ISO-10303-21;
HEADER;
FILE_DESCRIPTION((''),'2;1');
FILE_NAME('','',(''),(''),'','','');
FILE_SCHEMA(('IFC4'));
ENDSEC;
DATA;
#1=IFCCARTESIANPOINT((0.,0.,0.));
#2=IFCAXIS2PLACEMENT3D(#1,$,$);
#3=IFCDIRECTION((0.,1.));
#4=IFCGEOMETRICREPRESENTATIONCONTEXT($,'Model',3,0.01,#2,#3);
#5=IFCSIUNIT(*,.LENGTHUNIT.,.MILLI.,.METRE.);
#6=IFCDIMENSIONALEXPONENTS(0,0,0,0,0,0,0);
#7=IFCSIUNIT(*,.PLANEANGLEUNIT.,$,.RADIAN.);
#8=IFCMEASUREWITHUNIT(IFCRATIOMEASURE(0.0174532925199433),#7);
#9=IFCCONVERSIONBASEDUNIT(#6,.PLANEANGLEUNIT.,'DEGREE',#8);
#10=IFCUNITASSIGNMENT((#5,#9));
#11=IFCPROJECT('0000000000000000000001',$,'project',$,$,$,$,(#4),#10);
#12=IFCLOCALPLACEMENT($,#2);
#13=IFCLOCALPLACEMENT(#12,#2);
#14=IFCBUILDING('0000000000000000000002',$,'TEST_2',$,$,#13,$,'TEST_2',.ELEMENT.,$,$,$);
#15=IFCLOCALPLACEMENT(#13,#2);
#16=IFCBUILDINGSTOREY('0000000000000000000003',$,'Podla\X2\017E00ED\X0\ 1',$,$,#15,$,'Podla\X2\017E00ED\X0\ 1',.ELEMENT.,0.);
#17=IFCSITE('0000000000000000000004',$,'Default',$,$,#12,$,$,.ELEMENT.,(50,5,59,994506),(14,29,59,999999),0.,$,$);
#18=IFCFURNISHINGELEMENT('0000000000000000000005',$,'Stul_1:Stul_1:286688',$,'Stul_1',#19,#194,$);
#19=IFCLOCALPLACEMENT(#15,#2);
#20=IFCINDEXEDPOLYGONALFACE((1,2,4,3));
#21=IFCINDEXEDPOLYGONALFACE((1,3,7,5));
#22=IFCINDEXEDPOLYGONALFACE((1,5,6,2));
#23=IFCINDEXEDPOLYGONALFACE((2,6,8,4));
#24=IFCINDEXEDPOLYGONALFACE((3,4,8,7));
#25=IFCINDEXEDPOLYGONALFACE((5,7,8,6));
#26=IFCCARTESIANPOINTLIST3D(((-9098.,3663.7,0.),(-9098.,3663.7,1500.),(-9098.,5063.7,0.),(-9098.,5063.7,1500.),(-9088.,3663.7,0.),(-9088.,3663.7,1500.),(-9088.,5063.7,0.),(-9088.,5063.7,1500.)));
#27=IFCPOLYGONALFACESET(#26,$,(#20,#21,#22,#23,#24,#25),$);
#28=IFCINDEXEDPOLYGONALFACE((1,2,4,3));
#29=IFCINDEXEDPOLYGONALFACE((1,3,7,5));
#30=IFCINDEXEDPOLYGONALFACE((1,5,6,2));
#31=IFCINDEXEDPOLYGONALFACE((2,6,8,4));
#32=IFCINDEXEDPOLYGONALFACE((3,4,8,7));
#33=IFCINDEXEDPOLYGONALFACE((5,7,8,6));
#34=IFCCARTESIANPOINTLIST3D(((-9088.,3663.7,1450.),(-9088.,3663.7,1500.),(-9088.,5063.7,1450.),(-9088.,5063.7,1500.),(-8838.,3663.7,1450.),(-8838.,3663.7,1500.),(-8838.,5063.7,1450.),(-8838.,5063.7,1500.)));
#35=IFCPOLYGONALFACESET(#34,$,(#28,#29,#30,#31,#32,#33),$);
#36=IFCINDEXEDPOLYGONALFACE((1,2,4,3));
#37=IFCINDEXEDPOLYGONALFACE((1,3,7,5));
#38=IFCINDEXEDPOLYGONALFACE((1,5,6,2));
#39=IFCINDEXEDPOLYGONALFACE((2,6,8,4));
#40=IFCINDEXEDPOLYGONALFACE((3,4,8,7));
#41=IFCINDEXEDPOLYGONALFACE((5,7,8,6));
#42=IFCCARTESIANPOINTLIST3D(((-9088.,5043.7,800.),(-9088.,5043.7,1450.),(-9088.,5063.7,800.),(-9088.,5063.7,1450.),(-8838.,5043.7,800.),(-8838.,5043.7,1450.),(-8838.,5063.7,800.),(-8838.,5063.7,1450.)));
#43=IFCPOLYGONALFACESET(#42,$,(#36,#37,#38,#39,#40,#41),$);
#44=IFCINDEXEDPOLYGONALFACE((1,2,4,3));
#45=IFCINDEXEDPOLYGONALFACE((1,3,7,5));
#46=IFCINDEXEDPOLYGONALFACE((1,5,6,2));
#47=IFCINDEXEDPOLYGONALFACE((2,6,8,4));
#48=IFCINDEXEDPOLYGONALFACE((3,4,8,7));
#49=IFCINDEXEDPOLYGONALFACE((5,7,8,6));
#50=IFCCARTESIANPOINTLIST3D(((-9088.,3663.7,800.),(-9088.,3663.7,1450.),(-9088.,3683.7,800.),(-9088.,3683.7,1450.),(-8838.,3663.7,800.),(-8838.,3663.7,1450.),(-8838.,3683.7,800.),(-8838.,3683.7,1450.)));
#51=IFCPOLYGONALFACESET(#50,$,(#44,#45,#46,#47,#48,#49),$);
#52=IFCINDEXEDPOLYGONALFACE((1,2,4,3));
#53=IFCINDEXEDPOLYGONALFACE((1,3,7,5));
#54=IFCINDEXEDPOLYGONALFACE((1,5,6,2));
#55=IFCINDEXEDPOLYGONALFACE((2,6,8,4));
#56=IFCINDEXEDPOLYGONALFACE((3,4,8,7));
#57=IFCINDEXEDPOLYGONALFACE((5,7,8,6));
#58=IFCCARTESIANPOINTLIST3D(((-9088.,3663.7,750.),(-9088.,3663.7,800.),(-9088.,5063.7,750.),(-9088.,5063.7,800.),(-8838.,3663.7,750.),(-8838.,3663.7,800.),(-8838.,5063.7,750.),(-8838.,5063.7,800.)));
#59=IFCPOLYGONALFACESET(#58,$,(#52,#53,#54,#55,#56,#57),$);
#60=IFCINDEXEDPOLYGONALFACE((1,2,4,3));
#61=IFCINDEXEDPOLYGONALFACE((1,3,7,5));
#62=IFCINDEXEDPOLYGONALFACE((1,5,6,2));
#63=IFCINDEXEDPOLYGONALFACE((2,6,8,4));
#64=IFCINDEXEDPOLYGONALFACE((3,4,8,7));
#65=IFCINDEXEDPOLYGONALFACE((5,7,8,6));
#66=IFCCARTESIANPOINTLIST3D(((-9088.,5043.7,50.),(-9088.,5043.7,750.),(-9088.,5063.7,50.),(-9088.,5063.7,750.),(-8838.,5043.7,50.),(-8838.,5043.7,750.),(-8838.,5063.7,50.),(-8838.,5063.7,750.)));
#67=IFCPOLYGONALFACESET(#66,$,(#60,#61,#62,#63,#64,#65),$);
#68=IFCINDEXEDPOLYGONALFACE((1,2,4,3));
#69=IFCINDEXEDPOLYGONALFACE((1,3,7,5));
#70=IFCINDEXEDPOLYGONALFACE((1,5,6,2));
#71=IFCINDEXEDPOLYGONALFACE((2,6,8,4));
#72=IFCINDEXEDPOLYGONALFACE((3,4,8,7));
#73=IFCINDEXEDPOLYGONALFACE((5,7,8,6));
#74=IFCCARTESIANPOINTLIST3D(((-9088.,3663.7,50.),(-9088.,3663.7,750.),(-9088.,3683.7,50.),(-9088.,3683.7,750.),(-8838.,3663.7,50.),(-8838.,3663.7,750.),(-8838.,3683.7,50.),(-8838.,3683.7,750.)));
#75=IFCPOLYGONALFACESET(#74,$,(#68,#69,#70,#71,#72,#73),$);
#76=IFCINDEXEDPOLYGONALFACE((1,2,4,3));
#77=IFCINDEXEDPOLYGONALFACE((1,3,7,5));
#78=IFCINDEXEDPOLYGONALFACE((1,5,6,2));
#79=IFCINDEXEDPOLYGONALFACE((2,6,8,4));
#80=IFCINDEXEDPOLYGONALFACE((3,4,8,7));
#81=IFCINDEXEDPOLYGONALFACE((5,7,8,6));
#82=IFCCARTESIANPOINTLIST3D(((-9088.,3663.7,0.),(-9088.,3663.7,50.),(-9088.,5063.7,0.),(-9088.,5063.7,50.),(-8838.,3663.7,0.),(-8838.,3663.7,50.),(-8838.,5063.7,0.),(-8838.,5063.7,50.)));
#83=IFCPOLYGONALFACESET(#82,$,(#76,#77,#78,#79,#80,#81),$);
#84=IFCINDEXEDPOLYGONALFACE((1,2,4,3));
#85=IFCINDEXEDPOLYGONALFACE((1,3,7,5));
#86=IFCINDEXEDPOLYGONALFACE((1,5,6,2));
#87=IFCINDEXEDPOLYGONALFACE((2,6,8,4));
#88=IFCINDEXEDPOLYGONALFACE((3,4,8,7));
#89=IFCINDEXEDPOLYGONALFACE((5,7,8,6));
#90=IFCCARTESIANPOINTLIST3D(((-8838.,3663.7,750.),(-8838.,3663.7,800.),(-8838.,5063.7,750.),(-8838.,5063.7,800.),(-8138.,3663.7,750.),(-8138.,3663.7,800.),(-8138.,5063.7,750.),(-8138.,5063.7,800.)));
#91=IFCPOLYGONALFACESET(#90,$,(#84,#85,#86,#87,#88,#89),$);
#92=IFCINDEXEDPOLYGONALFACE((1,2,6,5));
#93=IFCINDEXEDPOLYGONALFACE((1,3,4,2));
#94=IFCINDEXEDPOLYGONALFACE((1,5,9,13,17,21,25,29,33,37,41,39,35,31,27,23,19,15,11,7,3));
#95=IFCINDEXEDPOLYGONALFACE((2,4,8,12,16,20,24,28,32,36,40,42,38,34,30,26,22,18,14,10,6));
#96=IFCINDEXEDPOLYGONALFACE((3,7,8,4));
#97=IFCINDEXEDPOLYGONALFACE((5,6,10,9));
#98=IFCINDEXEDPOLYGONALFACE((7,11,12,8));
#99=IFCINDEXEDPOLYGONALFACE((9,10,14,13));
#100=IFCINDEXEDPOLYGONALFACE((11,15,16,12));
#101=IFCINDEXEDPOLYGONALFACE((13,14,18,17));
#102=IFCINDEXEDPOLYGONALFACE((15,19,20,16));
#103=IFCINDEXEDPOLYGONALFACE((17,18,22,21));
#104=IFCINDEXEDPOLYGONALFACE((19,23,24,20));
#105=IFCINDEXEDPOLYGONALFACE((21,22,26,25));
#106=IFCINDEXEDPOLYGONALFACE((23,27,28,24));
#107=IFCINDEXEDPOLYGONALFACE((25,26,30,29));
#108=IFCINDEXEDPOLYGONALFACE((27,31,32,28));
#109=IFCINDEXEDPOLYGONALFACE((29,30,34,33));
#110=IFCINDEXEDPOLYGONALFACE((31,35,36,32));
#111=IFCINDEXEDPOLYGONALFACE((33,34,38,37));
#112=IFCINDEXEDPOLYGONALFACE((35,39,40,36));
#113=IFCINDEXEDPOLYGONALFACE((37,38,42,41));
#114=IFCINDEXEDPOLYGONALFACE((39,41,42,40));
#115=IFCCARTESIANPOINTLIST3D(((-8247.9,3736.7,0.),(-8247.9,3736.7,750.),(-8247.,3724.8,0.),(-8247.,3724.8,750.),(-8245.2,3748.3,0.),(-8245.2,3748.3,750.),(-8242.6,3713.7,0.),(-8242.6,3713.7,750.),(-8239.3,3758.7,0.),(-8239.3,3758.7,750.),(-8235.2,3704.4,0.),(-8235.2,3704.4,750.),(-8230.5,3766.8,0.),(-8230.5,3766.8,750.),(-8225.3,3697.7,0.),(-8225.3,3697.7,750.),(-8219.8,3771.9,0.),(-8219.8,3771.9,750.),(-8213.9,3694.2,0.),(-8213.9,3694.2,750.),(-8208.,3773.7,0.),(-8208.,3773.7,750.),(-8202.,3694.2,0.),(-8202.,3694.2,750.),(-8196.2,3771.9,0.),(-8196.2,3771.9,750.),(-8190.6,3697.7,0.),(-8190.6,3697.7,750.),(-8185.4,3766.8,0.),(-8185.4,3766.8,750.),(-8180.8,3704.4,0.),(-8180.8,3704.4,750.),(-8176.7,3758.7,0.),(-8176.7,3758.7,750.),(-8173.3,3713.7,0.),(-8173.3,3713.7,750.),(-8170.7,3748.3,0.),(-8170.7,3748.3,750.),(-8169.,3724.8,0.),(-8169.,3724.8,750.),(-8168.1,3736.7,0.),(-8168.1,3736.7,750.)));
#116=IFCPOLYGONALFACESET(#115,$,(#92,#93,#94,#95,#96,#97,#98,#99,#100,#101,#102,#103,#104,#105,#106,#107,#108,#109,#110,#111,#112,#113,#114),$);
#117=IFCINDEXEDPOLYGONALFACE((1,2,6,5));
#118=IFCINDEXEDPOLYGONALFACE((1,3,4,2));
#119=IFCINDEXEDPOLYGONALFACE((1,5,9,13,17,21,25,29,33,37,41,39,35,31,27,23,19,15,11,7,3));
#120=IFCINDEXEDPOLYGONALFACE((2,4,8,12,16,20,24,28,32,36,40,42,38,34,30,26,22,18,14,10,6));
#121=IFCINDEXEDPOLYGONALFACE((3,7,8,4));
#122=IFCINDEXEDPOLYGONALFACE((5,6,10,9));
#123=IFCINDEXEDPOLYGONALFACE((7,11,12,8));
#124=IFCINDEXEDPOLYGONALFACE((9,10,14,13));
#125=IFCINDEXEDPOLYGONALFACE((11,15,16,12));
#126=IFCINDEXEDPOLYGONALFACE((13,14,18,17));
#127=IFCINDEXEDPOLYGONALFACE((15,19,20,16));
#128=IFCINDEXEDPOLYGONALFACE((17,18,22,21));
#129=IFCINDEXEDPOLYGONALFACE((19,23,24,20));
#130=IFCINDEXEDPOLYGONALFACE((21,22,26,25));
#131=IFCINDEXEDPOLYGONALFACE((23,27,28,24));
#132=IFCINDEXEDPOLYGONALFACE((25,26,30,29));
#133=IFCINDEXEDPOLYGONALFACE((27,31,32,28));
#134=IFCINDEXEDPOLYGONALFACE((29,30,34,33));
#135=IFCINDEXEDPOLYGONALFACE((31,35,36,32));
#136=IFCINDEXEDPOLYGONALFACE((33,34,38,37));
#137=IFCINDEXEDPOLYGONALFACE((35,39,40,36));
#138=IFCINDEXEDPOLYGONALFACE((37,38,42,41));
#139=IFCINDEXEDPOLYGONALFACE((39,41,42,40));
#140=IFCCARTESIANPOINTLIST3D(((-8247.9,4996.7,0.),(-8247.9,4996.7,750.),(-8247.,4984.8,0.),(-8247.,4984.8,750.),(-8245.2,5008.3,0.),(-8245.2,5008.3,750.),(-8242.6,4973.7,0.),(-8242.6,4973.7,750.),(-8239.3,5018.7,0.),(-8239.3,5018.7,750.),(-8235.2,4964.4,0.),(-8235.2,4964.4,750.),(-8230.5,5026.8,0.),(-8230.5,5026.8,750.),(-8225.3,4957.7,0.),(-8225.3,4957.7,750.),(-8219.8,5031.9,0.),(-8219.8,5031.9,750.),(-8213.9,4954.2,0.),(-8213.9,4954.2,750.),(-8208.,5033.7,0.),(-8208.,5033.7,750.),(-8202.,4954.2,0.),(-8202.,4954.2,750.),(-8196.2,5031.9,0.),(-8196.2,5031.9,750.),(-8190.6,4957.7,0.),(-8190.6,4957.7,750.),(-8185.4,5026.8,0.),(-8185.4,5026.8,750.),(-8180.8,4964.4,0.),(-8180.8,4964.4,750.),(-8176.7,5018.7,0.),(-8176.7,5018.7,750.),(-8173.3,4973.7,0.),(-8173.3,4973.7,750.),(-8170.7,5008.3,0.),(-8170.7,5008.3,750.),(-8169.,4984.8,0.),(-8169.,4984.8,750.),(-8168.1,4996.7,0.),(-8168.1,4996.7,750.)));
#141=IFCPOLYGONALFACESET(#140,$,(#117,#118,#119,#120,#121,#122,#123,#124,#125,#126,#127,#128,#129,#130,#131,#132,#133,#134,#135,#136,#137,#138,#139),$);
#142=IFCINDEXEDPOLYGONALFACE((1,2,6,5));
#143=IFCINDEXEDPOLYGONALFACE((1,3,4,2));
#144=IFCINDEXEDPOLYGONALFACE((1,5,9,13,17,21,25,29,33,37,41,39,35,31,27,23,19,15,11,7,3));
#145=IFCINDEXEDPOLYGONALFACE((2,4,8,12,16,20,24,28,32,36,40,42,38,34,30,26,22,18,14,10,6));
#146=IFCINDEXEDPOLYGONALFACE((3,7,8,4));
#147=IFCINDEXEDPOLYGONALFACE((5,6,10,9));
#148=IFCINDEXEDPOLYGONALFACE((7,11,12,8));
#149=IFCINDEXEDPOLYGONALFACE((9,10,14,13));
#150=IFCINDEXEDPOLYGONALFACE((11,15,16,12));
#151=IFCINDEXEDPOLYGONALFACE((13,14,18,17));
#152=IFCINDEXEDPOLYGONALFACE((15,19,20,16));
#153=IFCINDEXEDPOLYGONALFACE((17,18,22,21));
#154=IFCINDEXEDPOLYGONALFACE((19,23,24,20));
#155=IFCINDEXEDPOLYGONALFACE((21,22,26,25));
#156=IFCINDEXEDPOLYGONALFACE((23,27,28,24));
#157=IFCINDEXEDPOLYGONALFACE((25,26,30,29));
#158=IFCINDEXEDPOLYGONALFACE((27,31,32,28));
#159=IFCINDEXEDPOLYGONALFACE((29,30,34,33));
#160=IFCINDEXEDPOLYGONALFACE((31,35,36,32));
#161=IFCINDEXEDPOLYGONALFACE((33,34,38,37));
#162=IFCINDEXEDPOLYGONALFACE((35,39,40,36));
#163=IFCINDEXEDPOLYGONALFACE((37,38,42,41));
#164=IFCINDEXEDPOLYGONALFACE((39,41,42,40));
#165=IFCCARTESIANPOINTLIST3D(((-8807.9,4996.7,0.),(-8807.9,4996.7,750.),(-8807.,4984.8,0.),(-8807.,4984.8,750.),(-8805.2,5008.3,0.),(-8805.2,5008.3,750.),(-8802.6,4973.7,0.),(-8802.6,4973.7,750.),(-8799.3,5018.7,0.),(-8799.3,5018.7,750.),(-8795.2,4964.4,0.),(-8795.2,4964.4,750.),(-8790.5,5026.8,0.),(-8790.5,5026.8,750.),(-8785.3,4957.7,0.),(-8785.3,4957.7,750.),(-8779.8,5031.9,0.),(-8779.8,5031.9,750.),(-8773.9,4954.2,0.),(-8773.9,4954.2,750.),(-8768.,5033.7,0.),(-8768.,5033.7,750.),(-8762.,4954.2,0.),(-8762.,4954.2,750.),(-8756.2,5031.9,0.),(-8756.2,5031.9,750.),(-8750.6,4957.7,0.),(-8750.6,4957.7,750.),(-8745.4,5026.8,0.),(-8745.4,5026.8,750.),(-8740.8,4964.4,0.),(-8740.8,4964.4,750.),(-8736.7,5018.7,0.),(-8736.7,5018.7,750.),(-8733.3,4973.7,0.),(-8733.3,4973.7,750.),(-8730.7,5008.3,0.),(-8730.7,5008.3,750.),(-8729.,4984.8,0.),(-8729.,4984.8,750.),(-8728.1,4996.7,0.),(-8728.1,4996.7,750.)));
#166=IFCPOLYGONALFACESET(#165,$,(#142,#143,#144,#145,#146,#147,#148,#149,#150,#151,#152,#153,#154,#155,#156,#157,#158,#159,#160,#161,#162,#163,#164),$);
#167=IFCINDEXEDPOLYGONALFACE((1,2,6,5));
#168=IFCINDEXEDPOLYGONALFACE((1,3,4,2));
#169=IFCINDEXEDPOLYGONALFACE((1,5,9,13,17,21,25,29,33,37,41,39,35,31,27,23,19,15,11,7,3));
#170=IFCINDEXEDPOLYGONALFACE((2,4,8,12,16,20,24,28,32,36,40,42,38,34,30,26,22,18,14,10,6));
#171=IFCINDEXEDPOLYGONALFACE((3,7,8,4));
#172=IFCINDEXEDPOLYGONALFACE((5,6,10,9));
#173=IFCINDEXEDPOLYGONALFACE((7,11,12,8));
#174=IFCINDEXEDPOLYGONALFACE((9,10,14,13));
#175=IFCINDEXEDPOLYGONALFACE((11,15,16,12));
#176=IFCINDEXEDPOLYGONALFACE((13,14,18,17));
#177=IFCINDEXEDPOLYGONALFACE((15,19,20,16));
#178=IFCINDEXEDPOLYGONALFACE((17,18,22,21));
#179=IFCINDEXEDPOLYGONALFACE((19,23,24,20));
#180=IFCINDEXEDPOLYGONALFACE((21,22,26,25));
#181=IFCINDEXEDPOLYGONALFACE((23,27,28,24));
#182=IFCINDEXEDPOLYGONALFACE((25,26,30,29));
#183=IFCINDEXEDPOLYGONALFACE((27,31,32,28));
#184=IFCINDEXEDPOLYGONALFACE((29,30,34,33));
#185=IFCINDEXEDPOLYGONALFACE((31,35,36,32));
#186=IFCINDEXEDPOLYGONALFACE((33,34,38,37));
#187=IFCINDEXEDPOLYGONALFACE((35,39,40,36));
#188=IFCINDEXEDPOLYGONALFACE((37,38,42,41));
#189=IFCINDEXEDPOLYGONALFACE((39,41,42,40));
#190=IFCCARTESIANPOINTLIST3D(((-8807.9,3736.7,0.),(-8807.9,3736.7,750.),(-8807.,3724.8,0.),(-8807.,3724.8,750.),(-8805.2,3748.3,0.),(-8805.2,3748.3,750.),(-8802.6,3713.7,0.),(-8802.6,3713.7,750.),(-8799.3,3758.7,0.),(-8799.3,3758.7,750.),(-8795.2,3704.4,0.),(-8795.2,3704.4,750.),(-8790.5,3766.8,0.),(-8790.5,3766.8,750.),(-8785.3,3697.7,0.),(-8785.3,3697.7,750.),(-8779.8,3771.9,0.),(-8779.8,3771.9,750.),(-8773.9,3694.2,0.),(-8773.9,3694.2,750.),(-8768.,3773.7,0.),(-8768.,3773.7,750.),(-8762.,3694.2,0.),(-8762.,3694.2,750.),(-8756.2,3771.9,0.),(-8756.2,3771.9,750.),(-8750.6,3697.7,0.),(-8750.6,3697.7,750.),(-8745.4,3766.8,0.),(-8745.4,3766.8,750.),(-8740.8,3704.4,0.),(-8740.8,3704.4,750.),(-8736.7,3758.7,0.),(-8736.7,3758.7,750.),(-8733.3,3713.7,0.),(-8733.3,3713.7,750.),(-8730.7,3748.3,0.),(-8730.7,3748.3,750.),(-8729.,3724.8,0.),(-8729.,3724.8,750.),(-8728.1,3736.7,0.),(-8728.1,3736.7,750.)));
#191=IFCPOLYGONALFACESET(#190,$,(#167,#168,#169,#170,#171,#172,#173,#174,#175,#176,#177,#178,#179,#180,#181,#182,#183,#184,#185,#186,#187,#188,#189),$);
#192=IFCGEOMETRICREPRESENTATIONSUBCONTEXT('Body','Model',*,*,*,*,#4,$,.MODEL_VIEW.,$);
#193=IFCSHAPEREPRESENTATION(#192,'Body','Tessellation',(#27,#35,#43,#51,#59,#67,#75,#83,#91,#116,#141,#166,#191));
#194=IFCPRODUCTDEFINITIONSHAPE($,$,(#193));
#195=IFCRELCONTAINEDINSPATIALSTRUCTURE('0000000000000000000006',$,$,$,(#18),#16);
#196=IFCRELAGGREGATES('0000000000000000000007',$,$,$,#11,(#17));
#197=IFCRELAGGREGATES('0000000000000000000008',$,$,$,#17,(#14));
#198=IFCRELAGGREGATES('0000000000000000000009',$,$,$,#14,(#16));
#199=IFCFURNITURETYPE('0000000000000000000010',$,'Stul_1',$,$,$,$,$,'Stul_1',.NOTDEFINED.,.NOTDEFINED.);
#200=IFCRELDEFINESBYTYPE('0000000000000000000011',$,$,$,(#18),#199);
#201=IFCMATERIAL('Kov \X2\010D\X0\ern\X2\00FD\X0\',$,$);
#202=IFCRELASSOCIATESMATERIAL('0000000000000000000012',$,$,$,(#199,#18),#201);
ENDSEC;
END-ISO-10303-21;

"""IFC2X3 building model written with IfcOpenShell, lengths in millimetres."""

from ifc_helpers import new_model, entity, si_unit, converted_unit, direction, frame, frame_2d, origin, origin_2d_with_axis, place, context, subcontext, project, spatial, rectangle, circle, extrude, source, transform, mapped, material, type_object, type_shapes, element, save


model = new_model("IFC2X3")

# Units and contexts
model_context = context("Model", 3, precision=0.01, world=origin(), true_north=direction((0.0, 1.0)))
body_context = subcontext(model_context, "Body", "Model", "MODEL_VIEW")
ifc_project = project(units=[si_unit("LENGTHUNIT", "METRE", prefix="MILLI"), converted_unit("PLANEANGLEUNIT", "DEGREE", entity("IfcRatioMeasure", 0.0174532925199433), si_unit("PLANEANGLEUNIT", "RADIAN"), dimensions=[0, 0, 0, 0, 0, 0, 0])], contexts=[model_context])

# Site, building, storey
site_placement = place(None, origin())
site = spatial("IfcSite", under=ifc_project, at=site_placement, Name="Default", CompositionType="ELEMENT", RefLatitude=(50, 5, 59, 994506), RefLongitude=(14, 29, 59, 999999), RefElevation=0.0)
building_placement = place(site_placement, origin())
building = spatial("IfcBuilding", under=site, at=building_placement, Name="TEST_2", LongName="TEST_2", CompositionType="ELEMENT")
storey_placement = place(building_placement, origin())
storey = spatial("IfcBuildingStorey", under=building, at=storey_placement, Name="Podlaží 1", LongName="Podlaží 1", CompositionType="ELEMENT", Elevation=0.0)

# Furnishing element
ifc_material_1 = material(Name="Kov černý")
furniture_type = type_object("IfcFurnitureType", Name="Stul_1", ElementType="Stul_1", material=ifc_material_1)
shared_shape_1 = source(origin(), body_context, "Body", "SweptSolid", [
    extrude(rectangle(XDim=1400.0, YDim=10.0, at=origin_2d_with_axis()), frame((0.0, 605.0, 0.0), z_axis=(0.0, 0.0, 1.0), x_axis=(-1.0, 0.0, 0.0)), (0.0, 0.0, 1.0), 1500.0),
    extrude(rectangle(XDim=1400.0, YDim=250.0, at=frame_2d((0.0, 0.0), x_axis=(1.0, 0.0))), frame((0.0, 475.0, 1450.0), z_axis=(0.0, 0.0, 1.0), x_axis=(-1.0, 0.0, 0.0)), (0.0, 0.0, 1.0), 50.0),
    extrude(rectangle(XDim=20.0, YDim=250.0, at=origin_2d_with_axis()), frame((690.0, 475.0, 800.0), z_axis=(0.0, 0.0, 1.0), x_axis=(-1.0, 0.0, 0.0)), (0.0, 0.0, 1.0), 650.0),
    extrude(rectangle(XDim=20.0, YDim=250.0, at=frame_2d((0.0, 0.0), x_axis=(1.0, 0.0))), frame((-690.0, 475.0, 800.0), z_axis=(0.0, 0.0, 1.0), x_axis=(-1.0, 0.0, 0.0)), (0.0, 0.0, 1.0), 650.0),
    extrude(rectangle(XDim=1400.0, YDim=250.0, at=origin_2d_with_axis()), frame((0.0, 475.0, 750.0), z_axis=(0.0, 0.0, 1.0), x_axis=(-1.0, 0.0, 0.0)), (0.0, 0.0, 1.0), 50.0),
    extrude(rectangle(XDim=20.0, YDim=250.0, at=origin_2d_with_axis()), frame((690.0, 475.0, 50.0), z_axis=(0.0, 0.0, 1.0), x_axis=(-1.0, 0.0, 0.0)), (0.0, 0.0, 1.0), 700.0),
    extrude(rectangle(XDim=20.0, YDim=250.0, at=frame_2d((0.0, 0.0), x_axis=(1.0, 0.0))), frame((-690.0, 475.0, 50.0), z_axis=(0.0, 0.0, 1.0), x_axis=(-1.0, 0.0, 0.0)), (0.0, 0.0, 1.0), 700.0),
    extrude(rectangle(XDim=1400.0, YDim=250.0, at=origin_2d_with_axis()), frame((0.0, 475.0, 0.0), z_axis=(0.0, 0.0, 1.0), x_axis=(-1.0, 0.0, 0.0)), (0.0, 0.0, 1.0), 50.0),
    extrude(rectangle(XDim=1400.0, YDim=700.0, at=origin_2d_with_axis()), frame((0.0, 0.0, 750.0), z_axis=(0.0, 0.0, 1.0), x_axis=(-1.0, 0.0, 0.0)), (0.0, 0.0, 1.0), 50.0),
    extrude(circle(Radius=40.0, at=frame_2d((0.0, 0.0), x_axis=(1.0, 0.0))), frame((-630.0, -280.0, 0.0)), (0.0, 0.0, 1.0), 750.0),
    extrude(circle(Radius=40.0, at=frame_2d((0.0, 0.0), x_axis=(1.0, 0.0))), frame((630.0, -280.0, 0.0)), (0.0, 0.0, 1.0), 750.0),
    extrude(circle(Radius=40.0, at=frame_2d((0.0, 0.0), x_axis=(1.0, 0.0))), frame((630.0, 280.0, 0.0)), (0.0, 0.0, 1.0), 750.0),
    extrude(circle(Radius=40.0, at=frame_2d((0.0, 0.0), x_axis=(1.0, 0.0))), frame((-630.0, 280.0, 0.0)), (0.0, 0.0, 1.0), 750.0),
])
type_shapes(furniture_type, [shared_shape_1])
for number, where, z_axis, x_axis, name in (
    (1, (-8488.0, 4363.7, 0.0), (0.0, 0.0, 1.0), (0.0, 1.0, 0.0), "Stul_1:Stul_1:286688"),
):
    element("IfcFurnishingElement", number, at=place(storey_placement, frame(where, z_axis=z_axis, x_axis=x_axis)), inside=storey, type_object=furniture_type, material=ifc_material_1, Name=name, ObjectType="Stul_1", context=body_context, shape_type="MappedRepresentation", body=[
        mapped(shared_shape_1, transform((0.0, 0.0, 0.0), scale=1.0)),
    ])

save(model, "model.ifc")
